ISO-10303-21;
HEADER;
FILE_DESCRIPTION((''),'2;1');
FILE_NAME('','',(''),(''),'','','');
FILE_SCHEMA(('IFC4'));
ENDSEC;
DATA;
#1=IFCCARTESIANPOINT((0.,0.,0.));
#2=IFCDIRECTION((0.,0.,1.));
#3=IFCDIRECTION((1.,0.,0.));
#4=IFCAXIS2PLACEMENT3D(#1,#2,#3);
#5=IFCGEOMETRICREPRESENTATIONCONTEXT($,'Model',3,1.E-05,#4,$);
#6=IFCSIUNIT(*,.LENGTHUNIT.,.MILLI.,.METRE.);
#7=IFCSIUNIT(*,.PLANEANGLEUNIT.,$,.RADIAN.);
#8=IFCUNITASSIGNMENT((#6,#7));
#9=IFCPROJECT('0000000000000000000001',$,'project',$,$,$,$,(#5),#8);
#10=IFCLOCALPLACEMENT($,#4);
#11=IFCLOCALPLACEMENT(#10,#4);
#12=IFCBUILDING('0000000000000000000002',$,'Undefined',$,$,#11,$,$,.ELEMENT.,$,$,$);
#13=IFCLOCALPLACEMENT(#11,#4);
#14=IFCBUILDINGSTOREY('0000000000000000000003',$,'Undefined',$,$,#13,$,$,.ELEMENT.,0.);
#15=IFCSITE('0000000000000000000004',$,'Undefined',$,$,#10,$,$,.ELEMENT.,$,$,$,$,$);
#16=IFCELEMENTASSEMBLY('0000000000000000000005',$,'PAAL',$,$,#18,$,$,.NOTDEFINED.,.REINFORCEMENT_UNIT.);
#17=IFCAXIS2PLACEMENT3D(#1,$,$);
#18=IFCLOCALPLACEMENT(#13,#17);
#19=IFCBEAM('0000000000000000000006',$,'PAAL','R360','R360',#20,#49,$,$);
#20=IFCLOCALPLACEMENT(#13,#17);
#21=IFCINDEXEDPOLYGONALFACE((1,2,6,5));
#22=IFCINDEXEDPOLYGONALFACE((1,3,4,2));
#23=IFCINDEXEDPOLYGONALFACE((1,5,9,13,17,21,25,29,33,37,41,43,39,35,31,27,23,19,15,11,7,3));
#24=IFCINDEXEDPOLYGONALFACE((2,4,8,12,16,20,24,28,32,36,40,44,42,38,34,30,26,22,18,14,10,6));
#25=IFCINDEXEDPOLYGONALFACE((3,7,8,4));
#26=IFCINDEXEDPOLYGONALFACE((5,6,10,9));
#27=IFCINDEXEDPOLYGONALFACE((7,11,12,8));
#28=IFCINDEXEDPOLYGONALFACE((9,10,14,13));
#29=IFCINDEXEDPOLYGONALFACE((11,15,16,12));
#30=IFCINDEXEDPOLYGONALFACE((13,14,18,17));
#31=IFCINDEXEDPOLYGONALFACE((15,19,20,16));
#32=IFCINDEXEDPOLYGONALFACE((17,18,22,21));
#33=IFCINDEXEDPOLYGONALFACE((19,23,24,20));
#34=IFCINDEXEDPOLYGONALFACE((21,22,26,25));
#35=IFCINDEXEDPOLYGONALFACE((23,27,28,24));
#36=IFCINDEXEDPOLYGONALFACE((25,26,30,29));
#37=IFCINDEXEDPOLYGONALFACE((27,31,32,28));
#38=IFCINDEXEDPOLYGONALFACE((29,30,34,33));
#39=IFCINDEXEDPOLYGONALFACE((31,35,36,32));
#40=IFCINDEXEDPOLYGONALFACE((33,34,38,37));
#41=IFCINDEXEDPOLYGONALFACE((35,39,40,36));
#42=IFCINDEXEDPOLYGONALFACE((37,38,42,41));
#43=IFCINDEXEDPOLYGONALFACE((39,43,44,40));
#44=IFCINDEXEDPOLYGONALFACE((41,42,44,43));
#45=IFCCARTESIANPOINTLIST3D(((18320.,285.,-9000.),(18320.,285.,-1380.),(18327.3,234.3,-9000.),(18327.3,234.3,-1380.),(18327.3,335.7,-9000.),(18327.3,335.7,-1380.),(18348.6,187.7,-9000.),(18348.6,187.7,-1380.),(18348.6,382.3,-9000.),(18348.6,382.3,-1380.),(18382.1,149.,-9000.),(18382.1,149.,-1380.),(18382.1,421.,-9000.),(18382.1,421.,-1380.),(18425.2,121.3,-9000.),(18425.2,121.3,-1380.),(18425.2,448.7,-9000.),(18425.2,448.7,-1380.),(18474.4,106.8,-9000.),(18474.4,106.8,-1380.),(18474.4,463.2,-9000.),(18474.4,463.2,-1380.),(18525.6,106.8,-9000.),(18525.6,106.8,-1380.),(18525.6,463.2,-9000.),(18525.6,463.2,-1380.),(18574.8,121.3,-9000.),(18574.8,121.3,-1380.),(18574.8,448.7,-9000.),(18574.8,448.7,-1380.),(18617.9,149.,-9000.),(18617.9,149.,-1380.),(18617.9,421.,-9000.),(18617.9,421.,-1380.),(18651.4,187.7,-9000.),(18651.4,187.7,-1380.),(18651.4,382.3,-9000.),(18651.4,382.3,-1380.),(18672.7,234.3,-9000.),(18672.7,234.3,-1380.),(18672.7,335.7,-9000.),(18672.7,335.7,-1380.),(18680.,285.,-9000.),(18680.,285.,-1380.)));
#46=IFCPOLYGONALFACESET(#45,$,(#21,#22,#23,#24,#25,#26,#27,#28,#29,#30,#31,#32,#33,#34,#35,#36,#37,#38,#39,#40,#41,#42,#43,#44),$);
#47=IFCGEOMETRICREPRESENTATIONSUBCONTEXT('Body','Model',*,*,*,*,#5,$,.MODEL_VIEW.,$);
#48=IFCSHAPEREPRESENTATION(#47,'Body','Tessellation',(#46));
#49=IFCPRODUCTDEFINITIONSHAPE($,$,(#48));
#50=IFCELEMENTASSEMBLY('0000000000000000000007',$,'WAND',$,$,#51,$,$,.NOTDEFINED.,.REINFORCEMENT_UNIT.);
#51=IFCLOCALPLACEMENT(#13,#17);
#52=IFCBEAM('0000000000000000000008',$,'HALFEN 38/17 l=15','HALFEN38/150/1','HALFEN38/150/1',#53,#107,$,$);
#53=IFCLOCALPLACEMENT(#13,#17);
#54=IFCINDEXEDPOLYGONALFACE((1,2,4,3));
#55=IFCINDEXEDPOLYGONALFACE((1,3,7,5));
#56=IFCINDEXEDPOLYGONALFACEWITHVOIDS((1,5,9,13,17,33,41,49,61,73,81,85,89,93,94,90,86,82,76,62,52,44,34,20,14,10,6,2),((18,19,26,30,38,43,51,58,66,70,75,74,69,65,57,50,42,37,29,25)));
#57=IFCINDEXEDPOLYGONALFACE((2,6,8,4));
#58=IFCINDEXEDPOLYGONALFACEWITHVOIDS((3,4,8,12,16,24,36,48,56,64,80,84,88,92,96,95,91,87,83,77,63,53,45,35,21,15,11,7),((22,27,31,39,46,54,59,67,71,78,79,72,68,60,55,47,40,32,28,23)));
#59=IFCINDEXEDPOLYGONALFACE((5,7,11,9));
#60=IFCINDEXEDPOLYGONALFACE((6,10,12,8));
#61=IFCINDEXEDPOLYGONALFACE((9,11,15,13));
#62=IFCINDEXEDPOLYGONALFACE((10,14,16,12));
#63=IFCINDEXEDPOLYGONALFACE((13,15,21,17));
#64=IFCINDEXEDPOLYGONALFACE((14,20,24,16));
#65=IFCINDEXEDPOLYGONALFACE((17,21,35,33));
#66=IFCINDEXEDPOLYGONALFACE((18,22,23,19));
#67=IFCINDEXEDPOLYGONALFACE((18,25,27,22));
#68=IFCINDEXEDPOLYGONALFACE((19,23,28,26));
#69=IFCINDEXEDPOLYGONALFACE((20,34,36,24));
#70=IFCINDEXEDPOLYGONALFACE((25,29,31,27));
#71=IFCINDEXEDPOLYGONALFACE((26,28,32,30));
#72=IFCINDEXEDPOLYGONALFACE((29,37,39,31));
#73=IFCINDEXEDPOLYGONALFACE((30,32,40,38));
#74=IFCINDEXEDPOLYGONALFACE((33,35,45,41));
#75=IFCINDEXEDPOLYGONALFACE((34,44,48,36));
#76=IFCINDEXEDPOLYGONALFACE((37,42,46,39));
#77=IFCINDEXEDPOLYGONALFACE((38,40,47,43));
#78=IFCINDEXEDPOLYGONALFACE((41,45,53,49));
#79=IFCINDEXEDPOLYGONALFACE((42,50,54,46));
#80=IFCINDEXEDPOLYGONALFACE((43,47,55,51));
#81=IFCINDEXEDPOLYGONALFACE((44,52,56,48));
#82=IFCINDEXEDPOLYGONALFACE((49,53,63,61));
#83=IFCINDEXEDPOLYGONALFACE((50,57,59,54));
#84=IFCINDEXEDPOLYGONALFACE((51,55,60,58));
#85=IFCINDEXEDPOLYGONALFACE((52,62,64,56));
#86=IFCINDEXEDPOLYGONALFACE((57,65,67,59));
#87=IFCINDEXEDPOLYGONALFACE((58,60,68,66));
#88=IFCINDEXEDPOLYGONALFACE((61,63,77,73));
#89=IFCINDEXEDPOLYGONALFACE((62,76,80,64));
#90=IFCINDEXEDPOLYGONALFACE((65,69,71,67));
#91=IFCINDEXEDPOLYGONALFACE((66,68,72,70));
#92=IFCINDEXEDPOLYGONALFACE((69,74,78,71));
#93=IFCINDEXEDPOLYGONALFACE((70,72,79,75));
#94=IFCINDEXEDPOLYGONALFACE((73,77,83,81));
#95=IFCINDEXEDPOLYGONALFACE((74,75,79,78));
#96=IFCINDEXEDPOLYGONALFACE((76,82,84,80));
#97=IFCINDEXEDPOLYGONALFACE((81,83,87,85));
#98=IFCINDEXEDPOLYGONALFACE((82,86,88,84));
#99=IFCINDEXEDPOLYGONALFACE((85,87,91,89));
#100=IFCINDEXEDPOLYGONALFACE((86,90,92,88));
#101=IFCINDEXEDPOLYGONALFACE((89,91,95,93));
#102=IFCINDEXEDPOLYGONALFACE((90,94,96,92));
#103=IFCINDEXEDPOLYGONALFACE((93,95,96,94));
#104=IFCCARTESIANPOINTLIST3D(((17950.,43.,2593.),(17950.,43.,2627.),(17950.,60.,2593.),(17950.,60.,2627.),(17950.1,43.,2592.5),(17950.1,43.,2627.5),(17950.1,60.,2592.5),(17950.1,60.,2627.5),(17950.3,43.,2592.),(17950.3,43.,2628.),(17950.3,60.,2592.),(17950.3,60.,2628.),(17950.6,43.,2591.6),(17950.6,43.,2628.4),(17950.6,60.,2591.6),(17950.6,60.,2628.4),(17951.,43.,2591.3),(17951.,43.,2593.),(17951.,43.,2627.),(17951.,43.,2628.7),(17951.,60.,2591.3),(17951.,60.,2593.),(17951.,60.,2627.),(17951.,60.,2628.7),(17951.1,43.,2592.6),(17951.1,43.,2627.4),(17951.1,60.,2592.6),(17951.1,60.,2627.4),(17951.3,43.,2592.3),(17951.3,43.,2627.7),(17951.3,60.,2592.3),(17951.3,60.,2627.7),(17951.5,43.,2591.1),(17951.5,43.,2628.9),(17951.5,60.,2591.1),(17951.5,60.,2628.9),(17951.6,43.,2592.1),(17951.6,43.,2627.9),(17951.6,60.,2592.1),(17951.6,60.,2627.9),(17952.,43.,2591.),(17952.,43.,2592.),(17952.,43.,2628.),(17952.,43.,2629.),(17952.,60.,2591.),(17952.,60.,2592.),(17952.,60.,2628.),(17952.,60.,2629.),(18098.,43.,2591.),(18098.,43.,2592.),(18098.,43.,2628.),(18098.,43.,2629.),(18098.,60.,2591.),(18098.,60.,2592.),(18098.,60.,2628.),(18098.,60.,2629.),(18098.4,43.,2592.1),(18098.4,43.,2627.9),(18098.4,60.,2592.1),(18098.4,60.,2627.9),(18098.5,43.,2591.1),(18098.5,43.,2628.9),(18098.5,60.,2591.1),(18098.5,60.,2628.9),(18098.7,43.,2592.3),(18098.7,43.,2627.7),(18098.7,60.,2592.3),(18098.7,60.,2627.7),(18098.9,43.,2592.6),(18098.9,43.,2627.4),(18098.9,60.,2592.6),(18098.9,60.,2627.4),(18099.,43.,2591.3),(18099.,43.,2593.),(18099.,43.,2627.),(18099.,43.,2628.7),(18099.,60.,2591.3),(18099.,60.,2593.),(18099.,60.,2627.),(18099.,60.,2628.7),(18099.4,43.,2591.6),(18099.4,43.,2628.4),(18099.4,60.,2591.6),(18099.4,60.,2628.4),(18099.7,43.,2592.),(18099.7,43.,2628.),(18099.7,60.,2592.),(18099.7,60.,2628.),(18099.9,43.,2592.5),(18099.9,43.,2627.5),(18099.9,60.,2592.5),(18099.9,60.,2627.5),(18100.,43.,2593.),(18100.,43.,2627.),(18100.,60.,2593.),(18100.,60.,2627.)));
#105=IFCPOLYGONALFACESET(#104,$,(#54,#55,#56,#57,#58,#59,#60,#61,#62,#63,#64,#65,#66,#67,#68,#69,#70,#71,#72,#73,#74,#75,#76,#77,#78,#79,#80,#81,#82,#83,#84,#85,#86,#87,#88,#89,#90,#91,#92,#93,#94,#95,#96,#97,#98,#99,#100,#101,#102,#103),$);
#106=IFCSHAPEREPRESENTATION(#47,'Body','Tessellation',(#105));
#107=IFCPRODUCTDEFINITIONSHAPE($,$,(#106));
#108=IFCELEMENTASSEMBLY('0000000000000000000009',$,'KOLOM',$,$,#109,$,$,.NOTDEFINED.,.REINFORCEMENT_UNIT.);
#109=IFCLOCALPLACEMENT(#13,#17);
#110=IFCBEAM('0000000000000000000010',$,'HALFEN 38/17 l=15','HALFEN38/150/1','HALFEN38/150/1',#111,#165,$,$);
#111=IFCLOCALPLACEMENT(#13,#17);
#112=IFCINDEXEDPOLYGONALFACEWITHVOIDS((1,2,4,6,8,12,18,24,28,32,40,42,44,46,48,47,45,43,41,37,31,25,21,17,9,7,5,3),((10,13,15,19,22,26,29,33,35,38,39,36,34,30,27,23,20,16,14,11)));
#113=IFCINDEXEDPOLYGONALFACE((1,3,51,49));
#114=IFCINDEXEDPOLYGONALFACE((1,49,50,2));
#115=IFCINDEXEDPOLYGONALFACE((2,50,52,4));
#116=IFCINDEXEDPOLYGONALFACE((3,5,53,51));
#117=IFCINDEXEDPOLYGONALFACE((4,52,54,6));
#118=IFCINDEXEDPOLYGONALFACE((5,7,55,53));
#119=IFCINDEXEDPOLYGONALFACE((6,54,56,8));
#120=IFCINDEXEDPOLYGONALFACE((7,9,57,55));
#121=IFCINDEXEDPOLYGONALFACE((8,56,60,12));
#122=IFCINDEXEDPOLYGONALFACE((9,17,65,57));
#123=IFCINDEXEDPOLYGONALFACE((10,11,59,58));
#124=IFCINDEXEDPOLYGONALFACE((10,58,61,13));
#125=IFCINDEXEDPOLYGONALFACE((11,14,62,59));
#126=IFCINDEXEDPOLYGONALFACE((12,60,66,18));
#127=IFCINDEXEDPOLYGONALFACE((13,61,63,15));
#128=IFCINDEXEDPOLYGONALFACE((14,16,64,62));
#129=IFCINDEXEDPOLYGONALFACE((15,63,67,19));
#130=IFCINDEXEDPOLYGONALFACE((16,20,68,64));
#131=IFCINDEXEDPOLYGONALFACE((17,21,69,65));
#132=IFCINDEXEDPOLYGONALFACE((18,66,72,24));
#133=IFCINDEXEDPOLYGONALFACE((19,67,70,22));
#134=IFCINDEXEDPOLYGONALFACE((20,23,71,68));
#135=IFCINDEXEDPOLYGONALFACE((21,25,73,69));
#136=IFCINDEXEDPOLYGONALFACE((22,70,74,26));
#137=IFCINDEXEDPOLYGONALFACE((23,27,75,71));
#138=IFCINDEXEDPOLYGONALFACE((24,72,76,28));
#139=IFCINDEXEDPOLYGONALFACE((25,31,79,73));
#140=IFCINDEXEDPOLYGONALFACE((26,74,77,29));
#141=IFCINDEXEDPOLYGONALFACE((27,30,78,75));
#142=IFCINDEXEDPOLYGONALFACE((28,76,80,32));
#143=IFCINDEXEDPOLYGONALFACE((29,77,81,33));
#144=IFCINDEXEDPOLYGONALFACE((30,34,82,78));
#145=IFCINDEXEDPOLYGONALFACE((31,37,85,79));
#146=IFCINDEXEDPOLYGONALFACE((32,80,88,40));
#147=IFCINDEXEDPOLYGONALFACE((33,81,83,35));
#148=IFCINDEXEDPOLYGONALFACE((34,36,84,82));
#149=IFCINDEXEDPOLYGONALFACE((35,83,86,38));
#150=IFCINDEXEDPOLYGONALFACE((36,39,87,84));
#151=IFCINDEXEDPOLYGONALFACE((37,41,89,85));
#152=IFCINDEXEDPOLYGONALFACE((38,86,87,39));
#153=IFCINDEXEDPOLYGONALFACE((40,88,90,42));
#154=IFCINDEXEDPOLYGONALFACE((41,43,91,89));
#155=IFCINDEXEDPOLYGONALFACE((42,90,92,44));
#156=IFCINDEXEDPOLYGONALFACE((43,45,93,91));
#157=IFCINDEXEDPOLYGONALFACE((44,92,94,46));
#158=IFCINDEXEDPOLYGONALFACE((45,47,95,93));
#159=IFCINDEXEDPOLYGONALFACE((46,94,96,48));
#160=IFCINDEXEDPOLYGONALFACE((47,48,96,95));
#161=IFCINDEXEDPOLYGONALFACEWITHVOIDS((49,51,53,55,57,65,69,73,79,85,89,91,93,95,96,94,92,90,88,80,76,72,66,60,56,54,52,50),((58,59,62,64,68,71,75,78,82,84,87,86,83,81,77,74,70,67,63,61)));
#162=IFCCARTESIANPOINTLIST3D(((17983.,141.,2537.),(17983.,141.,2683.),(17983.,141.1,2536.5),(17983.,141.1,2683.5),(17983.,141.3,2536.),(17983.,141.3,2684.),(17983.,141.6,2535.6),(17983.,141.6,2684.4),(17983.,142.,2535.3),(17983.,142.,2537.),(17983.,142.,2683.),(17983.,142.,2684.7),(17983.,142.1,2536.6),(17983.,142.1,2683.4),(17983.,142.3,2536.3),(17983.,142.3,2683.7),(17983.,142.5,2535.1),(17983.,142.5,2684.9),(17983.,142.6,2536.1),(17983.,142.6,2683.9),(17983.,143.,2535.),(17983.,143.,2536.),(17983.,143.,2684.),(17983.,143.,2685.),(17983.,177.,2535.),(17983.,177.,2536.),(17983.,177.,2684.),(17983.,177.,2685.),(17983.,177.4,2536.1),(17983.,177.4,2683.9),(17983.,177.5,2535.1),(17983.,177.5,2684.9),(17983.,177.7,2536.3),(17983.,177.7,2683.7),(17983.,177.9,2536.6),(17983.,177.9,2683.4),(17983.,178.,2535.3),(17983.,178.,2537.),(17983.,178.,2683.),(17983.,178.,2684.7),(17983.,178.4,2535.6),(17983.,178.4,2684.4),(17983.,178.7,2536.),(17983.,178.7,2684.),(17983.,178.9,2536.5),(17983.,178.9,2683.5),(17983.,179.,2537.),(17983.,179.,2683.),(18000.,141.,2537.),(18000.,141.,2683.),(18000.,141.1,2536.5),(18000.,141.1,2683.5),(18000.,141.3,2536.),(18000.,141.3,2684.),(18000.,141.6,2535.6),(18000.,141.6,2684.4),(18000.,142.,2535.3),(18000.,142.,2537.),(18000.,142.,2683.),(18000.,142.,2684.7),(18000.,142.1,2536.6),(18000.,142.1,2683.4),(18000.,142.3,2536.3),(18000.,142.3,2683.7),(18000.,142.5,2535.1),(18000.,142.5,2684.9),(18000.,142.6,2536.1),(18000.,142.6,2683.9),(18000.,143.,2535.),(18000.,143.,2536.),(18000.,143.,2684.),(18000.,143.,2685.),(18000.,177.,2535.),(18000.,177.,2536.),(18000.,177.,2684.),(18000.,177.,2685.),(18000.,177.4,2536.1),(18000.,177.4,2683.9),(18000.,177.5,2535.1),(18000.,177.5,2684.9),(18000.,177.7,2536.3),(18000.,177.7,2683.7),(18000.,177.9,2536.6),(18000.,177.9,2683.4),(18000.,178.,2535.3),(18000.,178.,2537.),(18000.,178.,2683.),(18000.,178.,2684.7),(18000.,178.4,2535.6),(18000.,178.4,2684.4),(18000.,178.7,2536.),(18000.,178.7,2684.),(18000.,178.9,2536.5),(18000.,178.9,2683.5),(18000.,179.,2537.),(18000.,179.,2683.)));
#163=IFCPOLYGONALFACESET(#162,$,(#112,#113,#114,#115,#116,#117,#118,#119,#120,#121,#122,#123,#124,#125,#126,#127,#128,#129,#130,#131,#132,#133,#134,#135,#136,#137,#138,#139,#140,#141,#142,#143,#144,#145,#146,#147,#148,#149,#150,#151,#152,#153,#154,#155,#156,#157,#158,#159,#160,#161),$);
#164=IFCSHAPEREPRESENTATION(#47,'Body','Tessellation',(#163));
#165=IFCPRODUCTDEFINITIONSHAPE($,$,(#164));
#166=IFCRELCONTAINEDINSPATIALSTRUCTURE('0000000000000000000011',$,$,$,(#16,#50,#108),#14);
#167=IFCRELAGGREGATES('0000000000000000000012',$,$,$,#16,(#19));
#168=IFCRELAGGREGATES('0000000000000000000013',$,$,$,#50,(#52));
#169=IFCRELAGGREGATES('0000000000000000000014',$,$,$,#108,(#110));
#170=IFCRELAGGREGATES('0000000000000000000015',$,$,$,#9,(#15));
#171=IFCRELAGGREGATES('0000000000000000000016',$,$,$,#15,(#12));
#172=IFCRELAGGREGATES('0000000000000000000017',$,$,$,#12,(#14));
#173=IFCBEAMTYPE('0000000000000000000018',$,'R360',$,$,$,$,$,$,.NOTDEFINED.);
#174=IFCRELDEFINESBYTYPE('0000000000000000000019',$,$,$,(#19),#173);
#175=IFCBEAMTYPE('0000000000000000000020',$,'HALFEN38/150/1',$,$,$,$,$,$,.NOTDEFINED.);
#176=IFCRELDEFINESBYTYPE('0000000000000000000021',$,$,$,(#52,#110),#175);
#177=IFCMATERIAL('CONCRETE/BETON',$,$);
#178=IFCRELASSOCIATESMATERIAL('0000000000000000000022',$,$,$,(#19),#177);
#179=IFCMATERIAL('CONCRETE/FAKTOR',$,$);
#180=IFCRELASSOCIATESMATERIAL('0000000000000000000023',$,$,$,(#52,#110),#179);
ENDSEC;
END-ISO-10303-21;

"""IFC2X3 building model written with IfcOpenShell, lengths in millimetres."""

from ifc_helpers import new_model, si_unit, frame, frame_2d, origin_with_axes, place, context, subcontext, project, spatial, hollow_rectangle, circle, extrude, material, type_object, element, aggregate, save


model = new_model("IFC2X3")

# Units and contexts
model_context = context("Model", 3, precision=1e-05, world=origin_with_axes())
body_context = subcontext(model_context, "Body", "Model", "MODEL_VIEW")
ifc_project = project(units=[si_unit("LENGTHUNIT", "METRE", prefix="MILLI"), si_unit("PLANEANGLEUNIT", "RADIAN")], contexts=[model_context])

# Site, building, storey
site_placement = place(None, origin_with_axes())
site = spatial("IfcSite", under=ifc_project, at=site_placement, Name="Undefined", CompositionType="ELEMENT")
building_placement = place(site_placement, origin_with_axes())
building = spatial("IfcBuilding", under=site, at=building_placement, Name="Undefined", CompositionType="ELEMENT")
storey_placement = place(building_placement, origin_with_axes())
storey = spatial("IfcBuildingStorey", under=building, at=storey_placement, Name="Undefined", CompositionType="ELEMENT", Elevation=0.0)

# Element assemblies, beams
ifc_material_1 = material(Name="CONCRETE/FAKTOR")
assembly_1_placement = place(storey_placement, origin_with_axes())
assembly_1 = element("IfcElementAssembly", 1, at=assembly_1_placement, inside=storey, Name="PAAL", AssemblyPlace="NOTDEFINED", PredefinedType="REINFORCEMENT_UNIT")
ifc_material_2 = material(Name="CONCRETE/BETON")
beam_type_1 = type_object("IfcBeamType", Name="R360", PredefinedType="NOTDEFINED")
beam_1_placement = place(assembly_1_placement, frame((18500.0, 285.0, -1380.0), z_axis=(0.0, -1.0, 0.0), x_axis=(0.0, 0.0, -1.0)))
beam_1 = element("IfcBeam", 2, at=beam_1_placement, type_object=beam_type_1, material=ifc_material_2, Name="PAAL", Description="R360", ObjectType="R360", context=body_context, shape_type="SweptSolid", body=[
    extrude(circle(Radius=180.0, at=frame_2d((0.0, 0.0), x_axis=(1.0, 0.0))), frame((7620.0, 0.0, 0.0), z_axis=(-1.0, 0.0, 0.0), x_axis=(0.0, -1.0, 0.0)), (0.0, 0.0, 1.0), 7620.0),
])
aggregate(assembly_1, [beam_1])
assembly_2_placement = place(storey_placement, origin_with_axes())
assembly_2 = element("IfcElementAssembly", 3, at=assembly_2_placement, inside=storey, Name="WAND", AssemblyPlace="NOTDEFINED", PredefinedType="REINFORCEMENT_UNIT")
beam_type_2 = type_object("IfcBeamType", Name="HALFEN38/150/1", PredefinedType="NOTDEFINED")
beam_2_placement = place(assembly_2_placement, frame((18025.0, 60.0, 2610.0), z_axis=(0.0, 0.0, -1.0), x_axis=(0.0, -1.0, 0.0)))
beam_2 = element("IfcBeam", 4, at=beam_2_placement, type_object=beam_type_2, material=ifc_material_1, Name="HALFEN 38/17 l=15", Description="HALFEN38/150/1", ObjectType="HALFEN38/150/1", context=body_context, shape_type="SweptSolid", body=[
    extrude(hollow_rectangle(XDim=150.0, YDim=38.0, WallThickness=1.0, InnerFilletRadius=1.0, OuterFilletRadius=2.0, at=frame_2d((0.0, 0.0), x_axis=(1.0, 0.0))), frame((17.0, 0.0, 0.0), z_axis=(-1.0, 0.0, 0.0), x_axis=(0.0, -1.0, 0.0)), (0.0, 0.0, 1.0), 17.0),
])
aggregate(assembly_2, [beam_2])

# Element assembly, beam
assembly_3_placement = place(storey_placement, origin_with_axes())
assembly_3 = element("IfcElementAssembly", 5, at=assembly_3_placement, inside=storey, Name="KOLOM", AssemblyPlace="NOTDEFINED", PredefinedType="REINFORCEMENT_UNIT")
beam_3_placement = place(assembly_3_placement, frame((18000.0, 160.0, 2610.0), z_axis=(0.0, 1.0, 0.0), x_axis=(-1.0, 0.0, 0.0)))
beam_3 = element("IfcBeam", 6, at=beam_3_placement, type_object=beam_type_2, material=ifc_material_1, Name="HALFEN 38/17 l=15", Description="HALFEN38/150/1", ObjectType="HALFEN38/150/1", context=body_context, shape_type="SweptSolid", body=[
    extrude(hollow_rectangle(XDim=150.0, YDim=38.0, WallThickness=1.0, InnerFilletRadius=1.0, OuterFilletRadius=2.0, at=frame_2d((0.0, 0.0), x_axis=(1.0, 0.0))), frame((17.0, 0.0, 0.0), z_axis=(-1.0, 0.0, 0.0), x_axis=(0.0, -1.0, 0.0)), (0.0, 0.0, 1.0), 17.0),
])
aggregate(assembly_3, [beam_3])

save(model, "model.ifc")
